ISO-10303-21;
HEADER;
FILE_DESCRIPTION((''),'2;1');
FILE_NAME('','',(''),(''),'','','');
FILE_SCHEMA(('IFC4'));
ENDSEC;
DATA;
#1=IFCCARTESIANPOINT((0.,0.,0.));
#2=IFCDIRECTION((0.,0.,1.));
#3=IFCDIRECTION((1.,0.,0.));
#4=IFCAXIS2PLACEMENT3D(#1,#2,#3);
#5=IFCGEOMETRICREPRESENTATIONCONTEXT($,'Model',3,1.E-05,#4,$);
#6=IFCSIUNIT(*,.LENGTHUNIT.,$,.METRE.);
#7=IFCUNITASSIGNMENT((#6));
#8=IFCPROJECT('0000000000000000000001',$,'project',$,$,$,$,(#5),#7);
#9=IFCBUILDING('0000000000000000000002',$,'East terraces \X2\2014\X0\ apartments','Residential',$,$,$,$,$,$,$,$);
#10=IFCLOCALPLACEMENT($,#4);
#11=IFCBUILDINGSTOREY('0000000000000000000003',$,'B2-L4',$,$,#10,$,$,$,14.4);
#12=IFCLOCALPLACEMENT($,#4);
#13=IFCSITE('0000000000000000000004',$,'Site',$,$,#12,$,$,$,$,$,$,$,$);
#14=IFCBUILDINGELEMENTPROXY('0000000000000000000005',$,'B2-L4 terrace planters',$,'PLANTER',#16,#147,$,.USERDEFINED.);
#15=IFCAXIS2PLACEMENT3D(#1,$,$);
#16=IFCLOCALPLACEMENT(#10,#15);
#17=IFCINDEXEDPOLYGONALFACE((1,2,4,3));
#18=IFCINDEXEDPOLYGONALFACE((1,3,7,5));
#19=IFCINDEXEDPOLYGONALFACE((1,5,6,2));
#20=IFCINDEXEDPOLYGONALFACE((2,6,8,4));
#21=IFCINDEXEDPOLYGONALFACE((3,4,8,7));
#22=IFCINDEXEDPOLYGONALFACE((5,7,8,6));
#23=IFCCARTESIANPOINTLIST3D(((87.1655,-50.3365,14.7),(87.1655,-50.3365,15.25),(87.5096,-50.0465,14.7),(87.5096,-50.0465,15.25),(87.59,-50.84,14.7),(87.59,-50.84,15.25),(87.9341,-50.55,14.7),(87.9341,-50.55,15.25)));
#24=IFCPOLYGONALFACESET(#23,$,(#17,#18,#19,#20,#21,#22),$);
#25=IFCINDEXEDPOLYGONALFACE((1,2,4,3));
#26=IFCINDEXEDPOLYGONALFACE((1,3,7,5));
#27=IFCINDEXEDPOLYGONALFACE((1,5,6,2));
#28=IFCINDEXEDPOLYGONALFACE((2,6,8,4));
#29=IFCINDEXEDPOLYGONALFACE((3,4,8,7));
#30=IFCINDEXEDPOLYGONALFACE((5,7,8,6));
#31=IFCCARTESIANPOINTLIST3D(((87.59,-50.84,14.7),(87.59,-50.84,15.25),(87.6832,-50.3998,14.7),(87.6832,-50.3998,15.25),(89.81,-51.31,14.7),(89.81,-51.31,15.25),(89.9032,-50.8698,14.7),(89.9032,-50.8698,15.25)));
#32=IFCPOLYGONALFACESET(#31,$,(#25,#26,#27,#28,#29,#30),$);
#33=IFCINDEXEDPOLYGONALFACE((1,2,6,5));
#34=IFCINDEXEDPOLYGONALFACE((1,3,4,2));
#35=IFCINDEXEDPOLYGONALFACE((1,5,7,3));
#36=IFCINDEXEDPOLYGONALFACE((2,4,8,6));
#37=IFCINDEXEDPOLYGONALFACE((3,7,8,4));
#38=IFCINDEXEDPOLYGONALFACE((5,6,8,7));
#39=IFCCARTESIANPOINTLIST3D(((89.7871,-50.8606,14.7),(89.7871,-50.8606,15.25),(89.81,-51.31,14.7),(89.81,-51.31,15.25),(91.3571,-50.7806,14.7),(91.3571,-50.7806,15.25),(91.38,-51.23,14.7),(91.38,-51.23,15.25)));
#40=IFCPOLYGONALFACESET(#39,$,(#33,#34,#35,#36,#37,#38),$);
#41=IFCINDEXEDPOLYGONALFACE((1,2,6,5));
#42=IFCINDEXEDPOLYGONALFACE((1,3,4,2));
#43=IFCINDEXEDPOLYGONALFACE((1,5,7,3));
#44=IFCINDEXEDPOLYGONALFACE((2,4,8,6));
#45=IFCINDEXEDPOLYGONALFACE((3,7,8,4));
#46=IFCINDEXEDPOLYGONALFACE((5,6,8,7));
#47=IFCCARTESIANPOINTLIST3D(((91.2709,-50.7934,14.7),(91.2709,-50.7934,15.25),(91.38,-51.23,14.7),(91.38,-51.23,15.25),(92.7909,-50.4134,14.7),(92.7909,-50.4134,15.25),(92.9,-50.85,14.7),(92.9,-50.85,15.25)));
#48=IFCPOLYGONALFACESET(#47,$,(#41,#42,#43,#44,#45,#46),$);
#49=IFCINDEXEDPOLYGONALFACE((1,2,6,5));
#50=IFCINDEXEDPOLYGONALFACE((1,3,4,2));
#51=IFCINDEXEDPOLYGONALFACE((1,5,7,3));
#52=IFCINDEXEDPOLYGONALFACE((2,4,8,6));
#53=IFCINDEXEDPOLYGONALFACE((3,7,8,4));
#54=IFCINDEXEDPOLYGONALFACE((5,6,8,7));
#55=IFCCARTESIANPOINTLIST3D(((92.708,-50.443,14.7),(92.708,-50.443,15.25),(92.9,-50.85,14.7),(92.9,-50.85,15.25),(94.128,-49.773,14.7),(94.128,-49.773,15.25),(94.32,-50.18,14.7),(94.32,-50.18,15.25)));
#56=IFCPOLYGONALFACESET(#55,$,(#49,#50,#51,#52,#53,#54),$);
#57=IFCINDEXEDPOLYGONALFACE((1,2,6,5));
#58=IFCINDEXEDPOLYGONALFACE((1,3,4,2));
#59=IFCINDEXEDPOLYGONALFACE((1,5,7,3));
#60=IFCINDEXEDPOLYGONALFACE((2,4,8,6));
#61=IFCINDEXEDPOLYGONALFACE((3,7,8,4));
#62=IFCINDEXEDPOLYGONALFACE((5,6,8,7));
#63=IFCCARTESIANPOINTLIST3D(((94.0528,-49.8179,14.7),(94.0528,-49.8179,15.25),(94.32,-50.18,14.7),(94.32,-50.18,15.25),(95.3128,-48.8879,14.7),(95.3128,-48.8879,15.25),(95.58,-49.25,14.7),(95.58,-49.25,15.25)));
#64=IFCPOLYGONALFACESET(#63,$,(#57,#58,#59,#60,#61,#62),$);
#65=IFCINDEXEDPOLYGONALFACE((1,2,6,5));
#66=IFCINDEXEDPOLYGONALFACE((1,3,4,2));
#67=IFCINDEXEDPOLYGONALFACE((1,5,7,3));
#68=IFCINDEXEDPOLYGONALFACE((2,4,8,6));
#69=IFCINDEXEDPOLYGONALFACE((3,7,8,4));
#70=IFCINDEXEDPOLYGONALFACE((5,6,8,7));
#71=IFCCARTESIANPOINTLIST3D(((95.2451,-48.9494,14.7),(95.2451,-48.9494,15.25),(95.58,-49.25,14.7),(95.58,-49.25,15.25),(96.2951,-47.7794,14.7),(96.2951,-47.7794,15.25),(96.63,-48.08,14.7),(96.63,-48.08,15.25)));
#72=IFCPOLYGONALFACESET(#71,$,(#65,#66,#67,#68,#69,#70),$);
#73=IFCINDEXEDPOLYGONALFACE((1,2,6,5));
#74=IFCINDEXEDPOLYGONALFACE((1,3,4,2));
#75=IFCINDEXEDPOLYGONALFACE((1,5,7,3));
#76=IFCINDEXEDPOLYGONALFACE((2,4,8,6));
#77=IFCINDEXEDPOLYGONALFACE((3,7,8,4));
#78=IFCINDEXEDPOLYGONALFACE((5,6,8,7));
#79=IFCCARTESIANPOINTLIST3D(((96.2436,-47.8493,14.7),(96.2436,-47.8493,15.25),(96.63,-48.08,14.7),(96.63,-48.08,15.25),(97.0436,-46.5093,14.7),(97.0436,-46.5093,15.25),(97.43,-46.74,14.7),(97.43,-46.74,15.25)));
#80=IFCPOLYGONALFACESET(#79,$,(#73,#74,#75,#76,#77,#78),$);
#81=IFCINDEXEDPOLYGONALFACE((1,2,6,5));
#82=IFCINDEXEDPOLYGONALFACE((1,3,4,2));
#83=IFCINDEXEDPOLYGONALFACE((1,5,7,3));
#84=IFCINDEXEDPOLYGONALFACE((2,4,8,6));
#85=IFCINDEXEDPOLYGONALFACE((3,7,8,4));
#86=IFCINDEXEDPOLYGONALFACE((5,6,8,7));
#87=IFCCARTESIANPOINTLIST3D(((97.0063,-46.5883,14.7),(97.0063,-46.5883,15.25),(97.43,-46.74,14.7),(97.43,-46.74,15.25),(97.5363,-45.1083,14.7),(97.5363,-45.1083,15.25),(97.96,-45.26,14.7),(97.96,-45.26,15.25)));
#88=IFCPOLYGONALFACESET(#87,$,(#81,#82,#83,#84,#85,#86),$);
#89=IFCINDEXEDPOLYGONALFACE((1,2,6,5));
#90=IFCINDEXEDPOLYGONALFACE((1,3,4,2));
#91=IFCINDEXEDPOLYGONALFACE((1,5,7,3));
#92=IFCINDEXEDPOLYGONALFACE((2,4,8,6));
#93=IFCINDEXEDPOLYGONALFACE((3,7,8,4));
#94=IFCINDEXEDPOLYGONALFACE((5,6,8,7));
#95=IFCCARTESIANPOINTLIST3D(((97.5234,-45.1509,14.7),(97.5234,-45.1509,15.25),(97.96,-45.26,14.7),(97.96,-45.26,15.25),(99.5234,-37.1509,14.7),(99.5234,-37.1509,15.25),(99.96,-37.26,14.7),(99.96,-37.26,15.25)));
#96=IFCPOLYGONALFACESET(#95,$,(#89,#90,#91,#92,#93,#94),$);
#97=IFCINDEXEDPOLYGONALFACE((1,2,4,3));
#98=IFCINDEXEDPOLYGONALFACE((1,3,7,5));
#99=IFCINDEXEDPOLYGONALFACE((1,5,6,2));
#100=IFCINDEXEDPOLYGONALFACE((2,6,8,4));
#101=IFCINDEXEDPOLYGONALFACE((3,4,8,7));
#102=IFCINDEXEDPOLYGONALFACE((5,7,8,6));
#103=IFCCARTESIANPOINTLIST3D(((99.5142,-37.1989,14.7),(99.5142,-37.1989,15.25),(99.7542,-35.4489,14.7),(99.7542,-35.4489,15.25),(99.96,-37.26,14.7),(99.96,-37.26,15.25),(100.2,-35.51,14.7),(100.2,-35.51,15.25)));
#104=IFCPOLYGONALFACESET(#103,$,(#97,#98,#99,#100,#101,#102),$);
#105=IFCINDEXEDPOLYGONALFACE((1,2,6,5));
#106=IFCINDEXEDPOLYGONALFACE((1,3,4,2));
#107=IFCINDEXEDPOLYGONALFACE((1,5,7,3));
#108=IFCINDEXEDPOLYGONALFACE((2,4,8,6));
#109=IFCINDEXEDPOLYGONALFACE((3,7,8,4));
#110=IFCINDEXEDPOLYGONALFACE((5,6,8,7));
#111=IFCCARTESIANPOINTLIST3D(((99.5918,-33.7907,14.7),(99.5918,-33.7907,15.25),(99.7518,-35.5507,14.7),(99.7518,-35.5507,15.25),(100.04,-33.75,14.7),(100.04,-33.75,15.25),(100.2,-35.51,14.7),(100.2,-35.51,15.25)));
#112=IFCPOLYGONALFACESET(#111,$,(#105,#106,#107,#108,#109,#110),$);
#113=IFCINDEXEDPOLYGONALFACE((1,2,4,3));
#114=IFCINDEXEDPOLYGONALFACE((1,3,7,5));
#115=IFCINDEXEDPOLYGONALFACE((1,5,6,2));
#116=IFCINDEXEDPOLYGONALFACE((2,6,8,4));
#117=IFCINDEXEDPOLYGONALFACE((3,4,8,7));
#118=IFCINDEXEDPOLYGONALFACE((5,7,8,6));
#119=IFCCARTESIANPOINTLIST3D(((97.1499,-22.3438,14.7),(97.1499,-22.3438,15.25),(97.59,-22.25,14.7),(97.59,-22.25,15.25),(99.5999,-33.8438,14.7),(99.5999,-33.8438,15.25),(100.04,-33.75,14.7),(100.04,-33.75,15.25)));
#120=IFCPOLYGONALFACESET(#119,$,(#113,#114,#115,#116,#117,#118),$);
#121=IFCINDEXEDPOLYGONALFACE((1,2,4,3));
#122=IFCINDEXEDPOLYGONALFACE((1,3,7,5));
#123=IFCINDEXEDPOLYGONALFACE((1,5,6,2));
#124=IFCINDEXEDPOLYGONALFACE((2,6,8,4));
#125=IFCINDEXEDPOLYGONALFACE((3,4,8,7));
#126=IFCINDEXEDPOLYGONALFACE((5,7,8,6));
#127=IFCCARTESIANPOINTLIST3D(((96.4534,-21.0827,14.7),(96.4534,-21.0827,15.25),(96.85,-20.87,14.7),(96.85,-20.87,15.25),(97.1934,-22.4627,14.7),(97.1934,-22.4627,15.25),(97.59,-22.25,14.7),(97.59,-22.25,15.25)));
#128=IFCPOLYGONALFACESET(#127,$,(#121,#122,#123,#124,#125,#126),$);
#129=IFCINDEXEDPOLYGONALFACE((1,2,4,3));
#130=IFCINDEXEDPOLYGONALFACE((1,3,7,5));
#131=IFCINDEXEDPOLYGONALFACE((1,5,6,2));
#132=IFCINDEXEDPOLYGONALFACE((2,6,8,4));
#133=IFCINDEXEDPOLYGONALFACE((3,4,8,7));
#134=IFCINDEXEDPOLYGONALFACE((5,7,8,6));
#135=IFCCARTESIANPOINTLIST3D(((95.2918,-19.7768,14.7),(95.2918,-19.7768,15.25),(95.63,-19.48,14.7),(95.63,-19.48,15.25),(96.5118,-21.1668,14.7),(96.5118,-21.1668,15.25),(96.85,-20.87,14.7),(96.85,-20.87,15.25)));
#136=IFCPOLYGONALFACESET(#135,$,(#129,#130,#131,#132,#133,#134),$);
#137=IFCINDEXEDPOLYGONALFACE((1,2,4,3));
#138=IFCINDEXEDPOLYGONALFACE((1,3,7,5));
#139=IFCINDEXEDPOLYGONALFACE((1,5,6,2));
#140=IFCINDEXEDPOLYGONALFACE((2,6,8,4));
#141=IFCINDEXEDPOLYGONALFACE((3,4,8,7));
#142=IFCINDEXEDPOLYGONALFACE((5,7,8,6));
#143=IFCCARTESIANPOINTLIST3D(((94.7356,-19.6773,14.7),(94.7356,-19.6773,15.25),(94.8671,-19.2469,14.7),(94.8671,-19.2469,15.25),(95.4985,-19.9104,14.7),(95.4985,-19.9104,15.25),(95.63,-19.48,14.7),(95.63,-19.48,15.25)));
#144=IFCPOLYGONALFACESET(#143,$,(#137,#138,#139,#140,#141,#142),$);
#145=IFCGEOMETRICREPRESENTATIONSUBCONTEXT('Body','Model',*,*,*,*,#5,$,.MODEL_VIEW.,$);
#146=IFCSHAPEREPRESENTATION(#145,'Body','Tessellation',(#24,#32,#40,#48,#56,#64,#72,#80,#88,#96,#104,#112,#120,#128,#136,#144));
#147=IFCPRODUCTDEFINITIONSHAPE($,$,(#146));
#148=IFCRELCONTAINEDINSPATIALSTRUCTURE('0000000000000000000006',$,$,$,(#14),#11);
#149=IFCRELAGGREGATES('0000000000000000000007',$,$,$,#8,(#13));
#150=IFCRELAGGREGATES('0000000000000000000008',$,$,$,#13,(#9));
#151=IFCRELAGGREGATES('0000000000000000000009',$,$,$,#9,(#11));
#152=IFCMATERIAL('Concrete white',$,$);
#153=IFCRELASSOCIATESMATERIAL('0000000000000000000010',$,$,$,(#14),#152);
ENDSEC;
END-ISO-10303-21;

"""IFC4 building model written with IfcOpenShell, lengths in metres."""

from ifc_helpers import new_model, si_unit, frame, origin_with_axes, place, context, subcontext, project, spatial, polyline, outline, extrude, material, element, save


model = new_model("IFC4")

# Units and contexts
model_context = context("Model", 3, precision=1e-05, world=origin_with_axes())
body_context = subcontext(model_context, "Body", "Model", "MODEL_VIEW")
ifc_project = project(units=[si_unit("LENGTHUNIT", "METRE")], contexts=[model_context])

# Site, building, storey
site_placement = place(None, origin_with_axes())
site = spatial("IfcSite", under=ifc_project, at=site_placement, Name="Site")
building = spatial("IfcBuilding", under=site, Name="East terraces — apartments", Description="Residential")
storey_placement = place(None, origin_with_axes())
storey = spatial("IfcBuildingStorey", under=building, at=storey_placement, Name="B2-L4", Elevation=14.4)

# Building element proxy
ifc_material_1 = material(Name="Concrete white")
proxy_1_placement = place(storey_placement, origin_with_axes())
element("IfcBuildingElementProxy", 1, at=proxy_1_placement, inside=storey, material=ifc_material_1, Name="B2-L4 terrace planters", ObjectType="PLANTER", PredefinedType="USERDEFINED", context=body_context, shape_type="SweptSolid", body=[
    extrude(outline(polyline([(87.1655, -50.3365), (87.59, -50.84), (87.9341, -50.55), (87.5096, -50.0465), (87.1655, -50.3365)])), frame((0.0, 0.0, 14.7), z_axis=(0.0, 0.0, 1.0), x_axis=(1.0, 0.0, 0.0)), (0.0, 0.0, 1.0), 0.55),
    extrude(outline(polyline([(87.59, -50.84), (89.81, -51.31), (89.9032, -50.8698), (87.6832, -50.3998), (87.59, -50.84)])), frame((0.0, 0.0, 14.7), z_axis=(0.0, 0.0, 1.0), x_axis=(1.0, 0.0, 0.0)), (0.0, 0.0, 1.0), 0.55),
    extrude(outline(polyline([(89.81, -51.31), (91.38, -51.23), (91.3571, -50.7806), (89.7871, -50.8606), (89.81, -51.31)])), frame((0.0, 0.0, 14.7), z_axis=(0.0, 0.0, 1.0), x_axis=(1.0, 0.0, 0.0)), (0.0, 0.0, 1.0), 0.55),
    extrude(outline(polyline([(91.38, -51.23), (92.9, -50.85), (92.7909, -50.4134), (91.2709, -50.7934), (91.38, -51.23)])), frame((0.0, 0.0, 14.7), z_axis=(0.0, 0.0, 1.0), x_axis=(1.0, 0.0, 0.0)), (0.0, 0.0, 1.0), 0.55),
    extrude(outline(polyline([(92.9, -50.85), (94.32, -50.18), (94.128, -49.773), (92.708, -50.443), (92.9, -50.85)])), frame((0.0, 0.0, 14.7), z_axis=(0.0, 0.0, 1.0), x_axis=(1.0, 0.0, 0.0)), (0.0, 0.0, 1.0), 0.55),
    extrude(outline(polyline([(94.32, -50.18), (95.58, -49.25), (95.3128, -48.8879), (94.0528, -49.8179), (94.32, -50.18)])), frame((0.0, 0.0, 14.7), z_axis=(0.0, 0.0, 1.0), x_axis=(1.0, 0.0, 0.0)), (0.0, 0.0, 1.0), 0.55),
    extrude(outline(polyline([(95.58, -49.25), (96.63, -48.08), (96.2951, -47.7794), (95.2451, -48.9494), (95.58, -49.25)])), frame((0.0, 0.0, 14.7), z_axis=(0.0, 0.0, 1.0), x_axis=(1.0, 0.0, 0.0)), (0.0, 0.0, 1.0), 0.55),
    extrude(outline(polyline([(96.63, -48.08), (97.43, -46.74), (97.0436, -46.5093), (96.2436, -47.8493), (96.63, -48.08)])), frame((0.0, 0.0, 14.7), z_axis=(0.0, 0.0, 1.0), x_axis=(1.0, 0.0, 0.0)), (0.0, 0.0, 1.0), 0.55),
    extrude(outline(polyline([(97.43, -46.74), (97.96, -45.26), (97.5363, -45.1083), (97.0063, -46.5883), (97.43, -46.74)])), frame((0.0, 0.0, 14.7), z_axis=(0.0, 0.0, 1.0), x_axis=(1.0, 0.0, 0.0)), (0.0, 0.0, 1.0), 0.55),
    extrude(outline(polyline([(97.96, -45.26), (99.96, -37.26), (99.5234, -37.1509), (97.5234, -45.1509), (97.96, -45.26)])), frame((0.0, 0.0, 14.7), z_axis=(0.0, 0.0, 1.0), x_axis=(1.0, 0.0, 0.0)), (0.0, 0.0, 1.0), 0.55),
    extrude(outline(polyline([(99.96, -37.26), (100.2, -35.51), (99.7542, -35.4489), (99.5142, -37.1989), (99.96, -37.26)])), frame((0.0, 0.0, 14.7), z_axis=(0.0, 0.0, 1.0), x_axis=(1.0, 0.0, 0.0)), (0.0, 0.0, 1.0), 0.55),
    extrude(outline(polyline([(100.2, -35.51), (100.04, -33.75), (99.5918, -33.7907), (99.7518, -35.5507), (100.2, -35.51)])), frame((0.0, 0.0, 14.7), z_axis=(0.0, 0.0, 1.0), x_axis=(1.0, 0.0, 0.0)), (0.0, 0.0, 1.0), 0.55),
    extrude(outline(polyline([(100.04, -33.75), (97.59, -22.25), (97.1499, -22.3438), (99.5999, -33.8438), (100.04, -33.75)])), frame((0.0, 0.0, 14.7), z_axis=(0.0, 0.0, 1.0), x_axis=(1.0, 0.0, 0.0)), (0.0, 0.0, 1.0), 0.55),
    extrude(outline(polyline([(97.59, -22.25), (96.85, -20.87), (96.4534, -21.0827), (97.1934, -22.4627), (97.59, -22.25)])), frame((0.0, 0.0, 14.7), z_axis=(0.0, 0.0, 1.0), x_axis=(1.0, 0.0, 0.0)), (0.0, 0.0, 1.0), 0.55),
    extrude(outline(polyline([(96.85, -20.87), (95.63, -19.48), (95.2918, -19.7768), (96.5118, -21.1668), (96.85, -20.87)])), frame((0.0, 0.0, 14.7), z_axis=(0.0, 0.0, 1.0), x_axis=(1.0, 0.0, 0.0)), (0.0, 0.0, 1.0), 0.55),
    extrude(outline(polyline([(95.63, -19.48), (94.8671, -19.2469), (94.7356, -19.6773), (95.4985, -19.9104), (95.63, -19.48)])), frame((0.0, 0.0, 14.7), z_axis=(0.0, 0.0, 1.0), x_axis=(1.0, 0.0, 0.0)), (0.0, 0.0, 1.0), 0.55),
])

save(model, "model.ifc")
